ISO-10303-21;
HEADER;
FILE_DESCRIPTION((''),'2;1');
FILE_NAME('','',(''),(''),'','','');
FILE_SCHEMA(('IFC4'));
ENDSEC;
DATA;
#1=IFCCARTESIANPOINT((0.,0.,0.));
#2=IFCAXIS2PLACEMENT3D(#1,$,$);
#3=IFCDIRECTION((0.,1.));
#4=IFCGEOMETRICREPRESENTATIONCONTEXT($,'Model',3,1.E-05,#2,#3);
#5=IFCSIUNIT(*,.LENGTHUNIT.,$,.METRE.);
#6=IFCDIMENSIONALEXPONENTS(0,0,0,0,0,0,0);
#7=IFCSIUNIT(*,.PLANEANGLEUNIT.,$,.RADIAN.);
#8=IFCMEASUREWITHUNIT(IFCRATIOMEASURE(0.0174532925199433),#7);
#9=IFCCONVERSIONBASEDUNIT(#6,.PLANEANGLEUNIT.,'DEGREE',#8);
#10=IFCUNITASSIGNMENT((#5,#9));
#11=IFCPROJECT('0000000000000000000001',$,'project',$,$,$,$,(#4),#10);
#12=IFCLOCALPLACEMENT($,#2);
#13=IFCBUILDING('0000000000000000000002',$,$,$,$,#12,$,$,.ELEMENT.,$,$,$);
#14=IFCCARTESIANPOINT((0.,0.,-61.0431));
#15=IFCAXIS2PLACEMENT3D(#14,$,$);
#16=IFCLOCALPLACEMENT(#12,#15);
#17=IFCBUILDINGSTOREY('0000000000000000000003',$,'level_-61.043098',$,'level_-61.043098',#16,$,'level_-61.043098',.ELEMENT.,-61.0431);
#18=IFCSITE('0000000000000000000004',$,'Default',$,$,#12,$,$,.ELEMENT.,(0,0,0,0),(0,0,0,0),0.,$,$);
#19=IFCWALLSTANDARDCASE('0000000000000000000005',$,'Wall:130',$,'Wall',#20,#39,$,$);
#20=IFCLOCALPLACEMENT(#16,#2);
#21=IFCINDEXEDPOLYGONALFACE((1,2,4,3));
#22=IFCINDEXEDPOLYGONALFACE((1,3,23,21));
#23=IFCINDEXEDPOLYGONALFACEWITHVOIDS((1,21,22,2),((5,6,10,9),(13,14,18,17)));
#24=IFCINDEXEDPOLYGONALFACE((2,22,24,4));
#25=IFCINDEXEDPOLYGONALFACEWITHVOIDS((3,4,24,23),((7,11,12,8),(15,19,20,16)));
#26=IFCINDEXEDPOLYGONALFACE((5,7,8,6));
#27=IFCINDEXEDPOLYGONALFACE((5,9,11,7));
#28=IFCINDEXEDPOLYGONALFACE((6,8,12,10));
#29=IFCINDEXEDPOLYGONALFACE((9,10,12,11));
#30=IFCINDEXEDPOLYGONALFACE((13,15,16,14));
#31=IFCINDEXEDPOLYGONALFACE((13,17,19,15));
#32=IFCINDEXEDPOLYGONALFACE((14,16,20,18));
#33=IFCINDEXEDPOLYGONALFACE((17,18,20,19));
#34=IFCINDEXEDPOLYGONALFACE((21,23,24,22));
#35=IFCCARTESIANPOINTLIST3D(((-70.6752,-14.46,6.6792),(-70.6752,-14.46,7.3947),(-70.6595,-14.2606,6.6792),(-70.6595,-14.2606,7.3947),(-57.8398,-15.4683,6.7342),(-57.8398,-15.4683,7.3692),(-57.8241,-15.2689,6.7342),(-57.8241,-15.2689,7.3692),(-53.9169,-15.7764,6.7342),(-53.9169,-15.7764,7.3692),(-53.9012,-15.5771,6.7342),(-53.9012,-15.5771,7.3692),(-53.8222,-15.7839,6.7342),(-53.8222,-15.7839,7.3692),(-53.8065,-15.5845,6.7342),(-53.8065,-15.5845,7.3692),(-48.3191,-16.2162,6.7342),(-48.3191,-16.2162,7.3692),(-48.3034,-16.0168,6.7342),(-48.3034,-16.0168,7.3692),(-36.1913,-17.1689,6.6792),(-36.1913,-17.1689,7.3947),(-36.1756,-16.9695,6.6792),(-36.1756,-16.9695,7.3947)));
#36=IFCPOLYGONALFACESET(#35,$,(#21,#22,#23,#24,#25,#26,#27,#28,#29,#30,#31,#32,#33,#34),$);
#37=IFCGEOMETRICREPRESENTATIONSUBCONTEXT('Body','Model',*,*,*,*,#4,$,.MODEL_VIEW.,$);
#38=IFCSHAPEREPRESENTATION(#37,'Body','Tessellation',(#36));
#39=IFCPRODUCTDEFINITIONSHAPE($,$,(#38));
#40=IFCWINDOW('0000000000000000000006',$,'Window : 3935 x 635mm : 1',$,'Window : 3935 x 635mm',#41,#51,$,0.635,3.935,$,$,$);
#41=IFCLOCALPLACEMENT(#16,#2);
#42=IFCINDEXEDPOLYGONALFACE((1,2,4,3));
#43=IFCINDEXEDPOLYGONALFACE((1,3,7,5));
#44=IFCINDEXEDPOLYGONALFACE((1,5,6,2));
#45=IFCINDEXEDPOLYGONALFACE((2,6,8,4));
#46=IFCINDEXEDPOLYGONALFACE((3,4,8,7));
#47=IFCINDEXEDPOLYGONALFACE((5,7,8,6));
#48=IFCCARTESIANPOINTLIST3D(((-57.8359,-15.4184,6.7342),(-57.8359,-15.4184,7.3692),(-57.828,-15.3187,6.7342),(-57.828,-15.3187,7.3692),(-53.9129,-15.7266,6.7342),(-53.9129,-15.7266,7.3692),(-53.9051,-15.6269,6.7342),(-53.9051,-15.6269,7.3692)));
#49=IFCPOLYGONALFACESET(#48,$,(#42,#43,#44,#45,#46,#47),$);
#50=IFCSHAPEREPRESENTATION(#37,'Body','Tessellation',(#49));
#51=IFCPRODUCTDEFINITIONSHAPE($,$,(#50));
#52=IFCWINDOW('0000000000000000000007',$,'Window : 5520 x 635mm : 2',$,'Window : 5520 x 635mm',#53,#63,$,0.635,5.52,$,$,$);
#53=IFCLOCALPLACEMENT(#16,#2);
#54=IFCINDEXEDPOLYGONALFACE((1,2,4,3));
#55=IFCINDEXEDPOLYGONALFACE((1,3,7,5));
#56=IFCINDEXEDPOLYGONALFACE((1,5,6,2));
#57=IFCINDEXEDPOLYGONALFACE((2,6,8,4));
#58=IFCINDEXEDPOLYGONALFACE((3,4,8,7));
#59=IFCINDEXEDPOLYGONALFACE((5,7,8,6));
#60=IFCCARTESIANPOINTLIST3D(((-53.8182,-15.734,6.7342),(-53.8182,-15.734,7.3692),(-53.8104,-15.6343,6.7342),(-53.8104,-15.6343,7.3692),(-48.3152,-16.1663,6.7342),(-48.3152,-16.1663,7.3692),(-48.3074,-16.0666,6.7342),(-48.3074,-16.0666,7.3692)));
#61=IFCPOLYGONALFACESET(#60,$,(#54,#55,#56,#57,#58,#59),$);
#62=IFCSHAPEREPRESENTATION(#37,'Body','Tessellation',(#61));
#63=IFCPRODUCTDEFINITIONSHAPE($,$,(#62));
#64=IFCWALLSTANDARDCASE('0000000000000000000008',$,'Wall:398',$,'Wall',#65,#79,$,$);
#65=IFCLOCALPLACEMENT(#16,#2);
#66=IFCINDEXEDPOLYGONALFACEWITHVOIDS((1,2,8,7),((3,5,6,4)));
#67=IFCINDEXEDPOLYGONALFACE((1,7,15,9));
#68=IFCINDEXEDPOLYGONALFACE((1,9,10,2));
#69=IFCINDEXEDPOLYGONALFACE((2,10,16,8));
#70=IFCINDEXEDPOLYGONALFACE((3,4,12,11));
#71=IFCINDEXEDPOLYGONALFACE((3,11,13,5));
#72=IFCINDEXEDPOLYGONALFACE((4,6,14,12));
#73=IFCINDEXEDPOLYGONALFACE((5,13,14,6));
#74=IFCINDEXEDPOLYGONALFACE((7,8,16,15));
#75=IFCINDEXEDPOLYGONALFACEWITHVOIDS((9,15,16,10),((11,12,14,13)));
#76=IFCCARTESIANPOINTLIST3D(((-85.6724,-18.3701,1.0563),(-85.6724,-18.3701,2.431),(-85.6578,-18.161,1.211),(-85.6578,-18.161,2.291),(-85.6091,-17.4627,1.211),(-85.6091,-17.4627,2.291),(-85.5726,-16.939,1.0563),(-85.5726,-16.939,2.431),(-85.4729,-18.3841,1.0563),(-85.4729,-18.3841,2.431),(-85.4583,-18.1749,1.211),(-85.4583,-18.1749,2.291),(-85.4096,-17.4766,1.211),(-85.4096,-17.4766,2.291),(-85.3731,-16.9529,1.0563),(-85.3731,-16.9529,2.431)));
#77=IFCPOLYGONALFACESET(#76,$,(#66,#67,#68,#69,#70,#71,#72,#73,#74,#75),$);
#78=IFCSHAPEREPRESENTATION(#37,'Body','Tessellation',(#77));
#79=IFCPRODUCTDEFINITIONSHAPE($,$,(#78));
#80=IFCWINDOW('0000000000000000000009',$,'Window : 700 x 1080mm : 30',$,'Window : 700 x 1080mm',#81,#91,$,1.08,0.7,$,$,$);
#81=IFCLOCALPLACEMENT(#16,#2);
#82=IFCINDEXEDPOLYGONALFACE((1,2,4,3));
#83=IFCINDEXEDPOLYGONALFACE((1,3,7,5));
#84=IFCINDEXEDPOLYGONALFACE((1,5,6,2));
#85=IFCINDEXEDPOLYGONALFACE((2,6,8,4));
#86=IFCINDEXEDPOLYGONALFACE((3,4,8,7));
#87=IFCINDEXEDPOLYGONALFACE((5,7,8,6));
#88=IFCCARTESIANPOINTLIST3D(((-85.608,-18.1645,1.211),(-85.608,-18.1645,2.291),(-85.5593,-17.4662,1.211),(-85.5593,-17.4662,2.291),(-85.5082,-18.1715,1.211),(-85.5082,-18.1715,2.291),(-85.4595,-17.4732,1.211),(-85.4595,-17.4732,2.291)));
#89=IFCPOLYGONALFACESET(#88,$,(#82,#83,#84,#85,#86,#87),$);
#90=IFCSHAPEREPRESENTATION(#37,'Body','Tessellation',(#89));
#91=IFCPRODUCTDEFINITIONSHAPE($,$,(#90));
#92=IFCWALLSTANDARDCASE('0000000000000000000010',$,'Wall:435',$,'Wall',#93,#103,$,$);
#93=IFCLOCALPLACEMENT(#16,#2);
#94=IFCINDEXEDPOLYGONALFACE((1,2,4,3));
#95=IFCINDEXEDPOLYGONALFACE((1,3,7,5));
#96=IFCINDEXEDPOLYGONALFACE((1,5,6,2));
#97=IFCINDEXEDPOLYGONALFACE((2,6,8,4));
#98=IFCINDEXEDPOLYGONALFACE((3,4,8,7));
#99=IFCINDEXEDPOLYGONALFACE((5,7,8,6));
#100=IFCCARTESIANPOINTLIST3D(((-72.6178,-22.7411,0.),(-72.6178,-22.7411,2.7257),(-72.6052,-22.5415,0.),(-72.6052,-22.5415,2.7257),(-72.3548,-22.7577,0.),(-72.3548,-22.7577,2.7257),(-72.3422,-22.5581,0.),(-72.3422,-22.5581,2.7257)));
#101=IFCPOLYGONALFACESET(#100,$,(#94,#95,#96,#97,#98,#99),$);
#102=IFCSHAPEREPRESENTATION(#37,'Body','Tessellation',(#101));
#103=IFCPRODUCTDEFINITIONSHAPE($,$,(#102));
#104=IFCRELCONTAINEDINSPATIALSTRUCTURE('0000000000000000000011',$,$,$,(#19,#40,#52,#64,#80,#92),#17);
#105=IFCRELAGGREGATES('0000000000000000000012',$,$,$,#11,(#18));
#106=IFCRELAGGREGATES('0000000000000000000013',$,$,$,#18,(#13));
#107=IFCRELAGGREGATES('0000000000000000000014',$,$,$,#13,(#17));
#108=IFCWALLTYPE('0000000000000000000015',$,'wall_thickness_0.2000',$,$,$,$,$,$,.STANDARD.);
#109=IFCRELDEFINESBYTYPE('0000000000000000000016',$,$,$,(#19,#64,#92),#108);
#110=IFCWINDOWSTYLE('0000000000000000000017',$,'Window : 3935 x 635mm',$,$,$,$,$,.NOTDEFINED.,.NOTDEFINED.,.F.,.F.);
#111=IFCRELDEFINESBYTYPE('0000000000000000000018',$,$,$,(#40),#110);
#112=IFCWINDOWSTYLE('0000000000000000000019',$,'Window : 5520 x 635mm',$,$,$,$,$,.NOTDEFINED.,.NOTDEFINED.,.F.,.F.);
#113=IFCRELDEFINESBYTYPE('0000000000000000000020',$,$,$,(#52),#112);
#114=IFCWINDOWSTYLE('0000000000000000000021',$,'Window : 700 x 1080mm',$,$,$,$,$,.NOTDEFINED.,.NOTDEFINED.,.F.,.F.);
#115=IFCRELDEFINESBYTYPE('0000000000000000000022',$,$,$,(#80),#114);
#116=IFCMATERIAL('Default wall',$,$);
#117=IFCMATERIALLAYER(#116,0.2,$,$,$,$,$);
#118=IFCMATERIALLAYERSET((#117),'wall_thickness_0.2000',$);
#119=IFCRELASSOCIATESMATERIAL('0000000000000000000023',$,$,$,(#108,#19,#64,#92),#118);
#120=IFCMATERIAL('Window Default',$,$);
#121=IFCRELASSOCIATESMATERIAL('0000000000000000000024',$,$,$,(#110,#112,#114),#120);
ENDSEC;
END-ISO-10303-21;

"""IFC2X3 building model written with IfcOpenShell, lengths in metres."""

from ifc_helpers import new_model, entity, si_unit, converted_unit, direction, frame, frame_2d, origin, origin_2d_with_axis, place, context, subcontext, project, spatial, polyline, rectangle, outline, extrude, source, transform, mapped, material, layer, layer_set, layer_usage, type_object, type_shapes, element, fill, save


model = new_model("IFC2X3")

# Units and contexts
model_context = context("Model", 3, precision=1e-05, world=origin(), true_north=direction((0.0, 1.0)))
body_context = subcontext(model_context, "Body", "Model", "MODEL_VIEW")
ifc_project = project(units=[si_unit("LENGTHUNIT", "METRE"), converted_unit("PLANEANGLEUNIT", "DEGREE", entity("IfcRatioMeasure", 0.0174532925199433), si_unit("PLANEANGLEUNIT", "RADIAN"), dimensions=[0, 0, 0, 0, 0, 0, 0])], contexts=[model_context])

# Site, building, storey
placement_1 = place(None, origin())
site = spatial("IfcSite", under=ifc_project, at=placement_1, Name="Default", CompositionType="ELEMENT", RefLatitude=(0, 0, 0, 0), RefLongitude=(0, 0, 0, 0), RefElevation=0.0)
building = spatial("IfcBuilding", under=site, at=placement_1, CompositionType="ELEMENT")
storey_placement = place(placement_1, frame((0.0, 0.0, -61.0431)))
storey = spatial("IfcBuildingStorey", under=building, at=storey_placement, Name="level_-61.043098", ObjectType="level_-61.043098", LongName="level_-61.043098", CompositionType="ELEMENT", Elevation=-61.0431)

# Wall, openings, windows
ifc_material_1 = material(Name="Default wall")
ifc_layer = layer(ifc_material_1, 0.2)
ifc_layer_set = layer_set([ifc_layer], Name="wall_thickness_0.2000")
ifc_layer_usage = layer_usage(ifc_layer_set, "AXIS2", "POSITIVE", -0.1)
wall_type = type_object("IfcWallType", Name="wall_thickness_0.2000", PredefinedType="STANDARD", material=ifc_layer_set)
placement_2 = place(placement_1, frame((0.0, 0.0, -54.3639)))
wall_1_placement = place(placement_2, frame((-70.6674, -14.3603, 0.0), z_axis=(0.0, 0.0, 1.0), x_axis=(0.996929, -0.078313, 0.0)))
wall_1 = element("IfcWallStandardCase", 1, at=wall_1_placement, inside=storey, type_object=wall_type, material=ifc_layer_usage, Name="Wall:130", ObjectType="Wall", context=body_context, shape_type="SweptSolid", body=[
    extrude(outline(polyline([(34.5902, -0.1), (34.5902, 0.1), (0.0, 0.1), (0.0, -0.1), (34.5902, -0.1)])), origin(), (0.0, 0.0, 1.0), 0.7155),
])
opening_1_placement = place(wall_1_placement, frame((12.875, -0.1, 0.055)))
opening_1 = element("IfcOpeningElement", 2, at=opening_1_placement, cuts=wall_1, ObjectType="Opening", context=body_context, shape_type="SweptSolid", body=[
    extrude(rectangle(XDim=3.935, YDim=0.635, at=frame_2d((0.3175, 1.9675), x_axis=(0.0, 1.0))), frame((0.0, 0.0, 0.0), z_axis=(0.0, 1.0, 0.0), x_axis=(0.0, 0.0, 1.0)), (0.0, 0.0, 1.0), 0.2),
])
opening_2_placement = place(wall_1_placement, frame((16.905, -0.1, 0.055)))
opening_2 = element("IfcOpeningElement", 3, at=opening_2_placement, cuts=wall_1, ObjectType="Opening", context=body_context, shape_type="SweptSolid", body=[
    extrude(rectangle(XDim=5.52, YDim=0.635, at=frame_2d((0.3175, 2.76), x_axis=(0.0, 1.0))), frame((0.0, 0.0, 0.0), z_axis=(0.0, 1.0, 0.0), x_axis=(0.0, 0.0, 1.0)), (0.0, 0.0, 1.0), 0.2),
])
ifc_material_2 = material(Name="Window Default")
window_style_1 = type_object("IfcWindowStyle", Name="Window : 3935 x 635mm", ConstructionType="NOTDEFINED", OperationType="NOTDEFINED", ParameterTakesPrecedence=False, Sizeable=False, material=ifc_material_2)
shared_shape_1 = source(origin(), body_context, "Body", "SweptSolid", [
    extrude(rectangle(XDim=0.1, YDim=3.935, at=origin_2d_with_axis()), frame((1.9675, 0.1, 0.0), z_axis=(0.0, 0.0, 1.0), x_axis=(0.0, 1.0, 0.0)), (0.0, 0.0, 1.0), 0.635),
])
type_shapes(window_style_1, [shared_shape_1])
window_1_placement = place(opening_1_placement, origin())
window_1 = element("IfcWindow", 4, at=window_1_placement, inside=storey, type_object=window_style_1, Name="Window : 3935 x 635mm : 1", ObjectType="Window : 3935 x 635mm", OverallHeight=0.635, OverallWidth=3.935, context=body_context, shape_type="MappedRepresentation", body=[
    mapped(shared_shape_1, transform((0.0, 0.0, 0.0), scale=1.0)),
])
fill(opening_1, window_1)
window_style_2 = type_object("IfcWindowStyle", Name="Window : 5520 x 635mm", ConstructionType="NOTDEFINED", OperationType="NOTDEFINED", ParameterTakesPrecedence=False, Sizeable=False, material=ifc_material_2)
shared_shape_2 = source(origin(), body_context, "Body", "SweptSolid", [
    extrude(rectangle(XDim=0.1, YDim=5.52, at=origin_2d_with_axis()), frame((2.76, 0.1, 0.0), z_axis=(0.0, 0.0, 1.0), x_axis=(0.0, 1.0, 0.0)), (0.0, 0.0, 1.0), 0.635),
])
type_shapes(window_style_2, [shared_shape_2])
window_2_placement = place(opening_2_placement, origin())
window_2 = element("IfcWindow", 5, at=window_2_placement, inside=storey, type_object=window_style_2, Name="Window : 5520 x 635mm : 2", ObjectType="Window : 5520 x 635mm", OverallHeight=0.635, OverallWidth=5.52, context=body_context, shape_type="MappedRepresentation", body=[
    mapped(shared_shape_2, transform((0.0, 0.0, 0.0), scale=1.0)),
])
fill(opening_2, window_2)

# Wall, opening, window
placement_3 = place(placement_1, frame((0.0, 0.0, -59.9868)))
wall_2_placement = place(placement_3, frame((-85.4729, -16.9459, 0.0), z_axis=(0.0, 0.0, 1.0), x_axis=(-0.069571, -0.997577, 0.0)))
wall_2 = element("IfcWallStandardCase", 6, at=wall_2_placement, inside=storey, type_object=wall_type, material=ifc_layer_usage, Name="Wall:398", ObjectType="Wall", context=body_context, shape_type="SweptSolid", body=[
    extrude(outline(polyline([(1.4346, -0.1), (1.4346, 0.1), (0.0, 0.1), (0.0, -0.1), (1.4346, -0.1)])), origin(), (0.0, 0.0, 1.0), 1.3747),
])
opening_3_placement = place(wall_2_placement, frame((0.525, -0.1, 0.1547)))
opening_3 = element("IfcOpeningElement", 7, at=opening_3_placement, cuts=wall_2, ObjectType="Opening", context=body_context, shape_type="SweptSolid", body=[
    extrude(rectangle(XDim=0.7, YDim=1.08, at=frame_2d((0.54, 0.35), x_axis=(0.0, 1.0))), frame((0.0, 0.0, 0.0), z_axis=(0.0, 1.0, 0.0), x_axis=(0.0, 0.0, 1.0)), (0.0, 0.0, 1.0), 0.2),
])
window_style_3 = type_object("IfcWindowStyle", Name="Window : 700 x 1080mm", ConstructionType="NOTDEFINED", OperationType="NOTDEFINED", ParameterTakesPrecedence=False, Sizeable=False, material=ifc_material_2)
shared_shape_3 = source(origin(), body_context, "Body", "SweptSolid", [
    extrude(rectangle(XDim=0.1, YDim=0.7, at=origin_2d_with_axis()), frame((0.35, 0.1, 0.0), z_axis=(0.0, 0.0, 1.0), x_axis=(0.0, 1.0, 0.0)), (0.0, 0.0, 1.0), 1.08),
])
type_shapes(window_style_3, [shared_shape_3])
window_3_placement = place(opening_3_placement, origin())
window_3 = element("IfcWindow", 8, at=window_3_placement, inside=storey, type_object=window_style_3, Name="Window : 700 x 1080mm : 30", ObjectType="Window : 700 x 1080mm", OverallHeight=1.08, OverallWidth=0.7, context=body_context, shape_type="MappedRepresentation", body=[
    mapped(shared_shape_3, transform((0.0, 0.0, 0.0), scale=1.0)),
])
fill(opening_3, window_3)

# Wall
wall_3_placement = place(storey_placement, frame((-72.3485, -22.6579, 0.0), z_axis=(0.0, 0.0, 1.0), x_axis=(-0.998004, 0.063146, 0.0)))
element("IfcWallStandardCase", 9, at=wall_3_placement, inside=storey, type_object=wall_type, material=ifc_layer_usage, Name="Wall:435", ObjectType="Wall", context=body_context, shape_type="SweptSolid", body=[
    extrude(outline(polyline([(0.2635, -0.1), (0.2635, 0.1), (0.0, 0.1), (0.0, -0.1), (0.2635, -0.1)])), origin(), (0.0, 0.0, 1.0), 2.7257),
])

save(model, "model.ifc")
